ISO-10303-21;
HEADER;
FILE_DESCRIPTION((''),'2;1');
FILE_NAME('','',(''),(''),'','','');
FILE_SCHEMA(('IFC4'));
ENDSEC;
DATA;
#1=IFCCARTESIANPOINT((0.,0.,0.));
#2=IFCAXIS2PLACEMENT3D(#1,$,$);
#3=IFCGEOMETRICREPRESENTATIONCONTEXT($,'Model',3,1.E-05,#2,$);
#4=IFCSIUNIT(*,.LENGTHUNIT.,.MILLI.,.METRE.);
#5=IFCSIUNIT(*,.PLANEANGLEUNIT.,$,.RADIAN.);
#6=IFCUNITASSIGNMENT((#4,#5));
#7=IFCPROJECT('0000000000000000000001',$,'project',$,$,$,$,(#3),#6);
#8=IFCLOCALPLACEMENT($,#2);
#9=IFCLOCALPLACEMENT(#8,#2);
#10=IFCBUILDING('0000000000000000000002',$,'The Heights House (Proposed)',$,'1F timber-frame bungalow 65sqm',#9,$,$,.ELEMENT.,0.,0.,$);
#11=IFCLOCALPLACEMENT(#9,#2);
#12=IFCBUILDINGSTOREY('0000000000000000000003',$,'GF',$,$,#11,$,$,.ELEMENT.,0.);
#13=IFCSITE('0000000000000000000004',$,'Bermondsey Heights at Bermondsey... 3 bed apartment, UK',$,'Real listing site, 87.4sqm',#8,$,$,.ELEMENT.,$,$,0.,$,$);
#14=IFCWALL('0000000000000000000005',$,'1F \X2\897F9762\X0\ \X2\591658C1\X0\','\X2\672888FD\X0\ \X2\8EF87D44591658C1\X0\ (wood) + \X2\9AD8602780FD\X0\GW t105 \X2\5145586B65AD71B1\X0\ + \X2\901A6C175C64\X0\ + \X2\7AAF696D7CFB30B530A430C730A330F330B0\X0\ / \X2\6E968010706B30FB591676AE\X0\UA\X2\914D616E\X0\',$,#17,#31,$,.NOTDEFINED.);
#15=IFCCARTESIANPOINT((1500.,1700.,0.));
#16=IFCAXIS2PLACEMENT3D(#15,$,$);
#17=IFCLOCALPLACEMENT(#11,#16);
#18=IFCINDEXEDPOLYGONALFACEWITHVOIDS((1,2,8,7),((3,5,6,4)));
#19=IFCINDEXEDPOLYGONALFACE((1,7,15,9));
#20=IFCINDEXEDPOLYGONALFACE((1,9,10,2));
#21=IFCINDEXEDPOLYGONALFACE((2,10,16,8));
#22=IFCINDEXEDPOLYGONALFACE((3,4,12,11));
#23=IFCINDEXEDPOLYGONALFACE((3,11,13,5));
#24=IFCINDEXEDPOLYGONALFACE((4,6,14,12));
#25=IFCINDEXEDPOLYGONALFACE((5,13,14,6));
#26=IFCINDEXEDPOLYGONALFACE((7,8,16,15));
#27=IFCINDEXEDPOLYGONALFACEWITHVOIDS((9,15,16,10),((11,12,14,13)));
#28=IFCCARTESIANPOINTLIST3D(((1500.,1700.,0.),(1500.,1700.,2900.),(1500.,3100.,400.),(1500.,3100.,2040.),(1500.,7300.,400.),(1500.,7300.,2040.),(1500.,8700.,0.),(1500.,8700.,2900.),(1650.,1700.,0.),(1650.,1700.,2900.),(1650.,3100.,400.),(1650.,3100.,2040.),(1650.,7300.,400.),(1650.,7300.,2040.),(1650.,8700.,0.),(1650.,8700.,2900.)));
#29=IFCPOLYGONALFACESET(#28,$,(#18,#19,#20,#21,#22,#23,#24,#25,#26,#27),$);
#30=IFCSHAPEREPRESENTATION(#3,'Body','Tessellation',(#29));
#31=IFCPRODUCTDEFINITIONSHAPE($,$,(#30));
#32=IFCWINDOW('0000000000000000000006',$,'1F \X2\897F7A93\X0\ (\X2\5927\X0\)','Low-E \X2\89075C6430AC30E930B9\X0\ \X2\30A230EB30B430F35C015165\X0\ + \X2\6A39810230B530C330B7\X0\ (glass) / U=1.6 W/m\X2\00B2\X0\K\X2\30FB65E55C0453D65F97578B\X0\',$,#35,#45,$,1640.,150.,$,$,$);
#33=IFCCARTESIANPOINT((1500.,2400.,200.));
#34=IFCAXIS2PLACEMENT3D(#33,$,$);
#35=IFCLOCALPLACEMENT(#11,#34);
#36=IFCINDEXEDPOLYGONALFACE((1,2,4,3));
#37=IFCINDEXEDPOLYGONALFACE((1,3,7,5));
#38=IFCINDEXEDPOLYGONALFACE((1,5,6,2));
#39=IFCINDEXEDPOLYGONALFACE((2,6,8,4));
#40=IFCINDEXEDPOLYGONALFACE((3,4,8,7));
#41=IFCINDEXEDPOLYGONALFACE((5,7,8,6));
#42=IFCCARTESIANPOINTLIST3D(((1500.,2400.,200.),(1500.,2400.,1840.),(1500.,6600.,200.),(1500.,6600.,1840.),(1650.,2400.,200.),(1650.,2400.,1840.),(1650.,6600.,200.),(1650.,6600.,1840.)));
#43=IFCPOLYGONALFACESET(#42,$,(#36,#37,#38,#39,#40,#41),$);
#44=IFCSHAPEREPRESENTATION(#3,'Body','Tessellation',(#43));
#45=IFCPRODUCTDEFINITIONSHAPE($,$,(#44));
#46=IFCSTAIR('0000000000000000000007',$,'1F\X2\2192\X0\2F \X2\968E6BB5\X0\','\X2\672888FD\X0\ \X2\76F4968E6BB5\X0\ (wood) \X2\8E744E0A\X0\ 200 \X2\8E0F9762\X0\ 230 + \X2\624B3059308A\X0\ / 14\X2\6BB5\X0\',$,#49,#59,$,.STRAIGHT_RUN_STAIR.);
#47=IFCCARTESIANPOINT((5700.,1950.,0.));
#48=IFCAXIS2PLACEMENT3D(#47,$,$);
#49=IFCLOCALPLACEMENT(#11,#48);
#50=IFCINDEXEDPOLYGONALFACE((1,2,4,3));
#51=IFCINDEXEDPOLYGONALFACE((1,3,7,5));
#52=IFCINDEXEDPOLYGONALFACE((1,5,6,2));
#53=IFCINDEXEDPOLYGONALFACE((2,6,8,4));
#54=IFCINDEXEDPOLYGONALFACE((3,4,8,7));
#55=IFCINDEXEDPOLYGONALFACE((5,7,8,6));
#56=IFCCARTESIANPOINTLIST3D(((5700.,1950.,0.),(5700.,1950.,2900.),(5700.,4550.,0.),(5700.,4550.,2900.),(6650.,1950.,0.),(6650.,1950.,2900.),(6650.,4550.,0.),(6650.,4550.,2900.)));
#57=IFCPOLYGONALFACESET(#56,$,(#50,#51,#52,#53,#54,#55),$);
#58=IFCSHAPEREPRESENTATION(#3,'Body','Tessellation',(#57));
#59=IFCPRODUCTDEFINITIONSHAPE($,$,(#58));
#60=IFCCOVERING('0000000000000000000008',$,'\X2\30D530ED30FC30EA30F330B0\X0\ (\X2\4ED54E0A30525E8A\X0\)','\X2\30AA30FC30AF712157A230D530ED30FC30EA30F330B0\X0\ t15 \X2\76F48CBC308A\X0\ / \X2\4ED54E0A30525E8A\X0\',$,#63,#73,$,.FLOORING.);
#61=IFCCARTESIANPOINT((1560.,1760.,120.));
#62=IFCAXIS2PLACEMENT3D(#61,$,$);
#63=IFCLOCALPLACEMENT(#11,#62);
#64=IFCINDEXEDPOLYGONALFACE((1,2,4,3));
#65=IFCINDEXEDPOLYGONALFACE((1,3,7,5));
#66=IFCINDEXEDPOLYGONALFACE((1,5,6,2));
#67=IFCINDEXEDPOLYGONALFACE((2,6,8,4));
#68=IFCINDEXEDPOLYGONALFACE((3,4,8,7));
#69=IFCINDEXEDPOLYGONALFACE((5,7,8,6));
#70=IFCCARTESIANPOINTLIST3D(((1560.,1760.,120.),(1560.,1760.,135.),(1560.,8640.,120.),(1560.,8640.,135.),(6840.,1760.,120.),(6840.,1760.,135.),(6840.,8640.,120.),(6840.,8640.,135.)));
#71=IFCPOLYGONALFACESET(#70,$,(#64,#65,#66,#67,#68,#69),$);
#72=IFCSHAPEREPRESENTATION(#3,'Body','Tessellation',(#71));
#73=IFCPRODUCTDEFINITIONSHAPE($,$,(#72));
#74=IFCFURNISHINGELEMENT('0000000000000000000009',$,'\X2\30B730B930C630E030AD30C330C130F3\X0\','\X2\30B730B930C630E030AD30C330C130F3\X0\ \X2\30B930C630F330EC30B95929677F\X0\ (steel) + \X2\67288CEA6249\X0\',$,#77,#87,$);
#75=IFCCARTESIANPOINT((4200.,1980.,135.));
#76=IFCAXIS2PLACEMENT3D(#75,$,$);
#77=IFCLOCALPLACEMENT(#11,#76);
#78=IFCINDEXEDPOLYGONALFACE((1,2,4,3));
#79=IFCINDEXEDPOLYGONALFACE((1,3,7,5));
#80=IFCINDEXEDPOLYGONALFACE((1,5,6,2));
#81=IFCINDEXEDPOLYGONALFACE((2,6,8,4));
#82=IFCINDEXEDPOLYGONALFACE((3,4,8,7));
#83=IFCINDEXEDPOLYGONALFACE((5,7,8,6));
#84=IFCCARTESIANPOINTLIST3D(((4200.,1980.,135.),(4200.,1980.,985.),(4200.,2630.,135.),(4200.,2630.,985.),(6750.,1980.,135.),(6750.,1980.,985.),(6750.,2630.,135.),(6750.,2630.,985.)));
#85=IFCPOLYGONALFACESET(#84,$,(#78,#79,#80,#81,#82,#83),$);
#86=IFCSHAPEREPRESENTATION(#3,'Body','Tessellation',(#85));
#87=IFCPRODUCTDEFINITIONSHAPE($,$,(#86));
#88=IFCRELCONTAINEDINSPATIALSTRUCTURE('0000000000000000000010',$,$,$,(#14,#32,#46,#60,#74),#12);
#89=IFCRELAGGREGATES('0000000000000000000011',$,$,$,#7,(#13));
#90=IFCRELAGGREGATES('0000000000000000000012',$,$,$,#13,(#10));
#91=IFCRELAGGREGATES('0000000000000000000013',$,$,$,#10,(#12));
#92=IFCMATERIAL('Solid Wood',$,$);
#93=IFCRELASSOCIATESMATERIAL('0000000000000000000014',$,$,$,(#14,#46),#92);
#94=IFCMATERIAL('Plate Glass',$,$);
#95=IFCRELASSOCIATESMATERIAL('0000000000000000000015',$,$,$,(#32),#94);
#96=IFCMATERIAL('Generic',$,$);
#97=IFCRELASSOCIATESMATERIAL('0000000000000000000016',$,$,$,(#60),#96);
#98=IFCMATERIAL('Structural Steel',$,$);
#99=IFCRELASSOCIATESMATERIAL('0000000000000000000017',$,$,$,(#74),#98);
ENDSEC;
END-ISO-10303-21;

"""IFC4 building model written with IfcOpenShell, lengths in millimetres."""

from ifc_helpers import new_model, si_unit, frame, frame_2d, origin, place, context, project, spatial, rectangle, extrude, material, element, fill, save


model = new_model("IFC4")

# Units and contexts
model_context = context("Model", 3, precision=1e-05, world=origin())
ifc_project = project(units=[si_unit("LENGTHUNIT", "METRE", prefix="MILLI"), si_unit("PLANEANGLEUNIT", "RADIAN")], contexts=[model_context])

# Site, building, storey
site_placement = place(None, origin())
site = spatial("IfcSite", under=ifc_project, at=site_placement, Name="Bermondsey Heights at Bermondsey... 3 bed apartment, UK", ObjectType="Real listing site, 87.4sqm", CompositionType="ELEMENT", RefElevation=0.0)
building_placement = place(site_placement, origin())
building = spatial("IfcBuilding", under=site, at=building_placement, Name="The Heights House (Proposed)", ObjectType="1F timber-frame bungalow 65sqm", CompositionType="ELEMENT", ElevationOfRefHeight=0.0, ElevationOfTerrain=0.0)
storey_placement = place(building_placement, origin())
storey = spatial("IfcBuildingStorey", under=building, at=storey_placement, Name="GF", CompositionType="ELEMENT", Elevation=0.0)

# Shared definitions
ifc_material_1 = material(Name="Solid Wood")
ifc_material_2 = material(Name="Generic")

# Shared definitions
ifc_material_3 = material(Name="Plate Glass")

# Wall, opening, window
wall_1_placement = place(storey_placement, frame((1500.0, 1700.0, 0.0)))
wall_1 = element("IfcWall", 1, at=wall_1_placement, inside=storey, material=ifc_material_1, Name="1F 西面 外壁", Description="木製 軸組外壁 (wood) + 高性能GW t105 充填断熱 + 通気層 + 窯業系サイディング / 準耐火・外皮UA配慮", PredefinedType="NOTDEFINED", context=model_context, shape_type="SweptSolid", body=[
    extrude(rectangle(XDim=150.0, YDim=7000.0, at=frame_2d((75.0, 3500.0))), frame((1500.0, 1700.0, 0.0)), (0.0, 0.0, 1.0), 2900.0),
])
opening_1_placement = place(storey_placement, frame((1500.0, 2400.0, 200.0)))
opening_1 = element("IfcOpeningElement", 2, at=opening_1_placement, cuts=wall_1, PredefinedType="NOTDEFINED", context=model_context, shape_type="SweptSolid", body=[
    extrude(rectangle(XDim=150.0, YDim=4200.0, at=frame_2d((75.0, 2100.0))), frame((1500.0, 2400.0, 200.0)), (0.0, 0.0, 1.0), 1640.0),
])
window_1_placement = place(storey_placement, frame((1500.0, 2400.0, 200.0)))
window_1 = element("IfcWindow", 3, at=window_1_placement, inside=storey, material=ifc_material_3, Name="1F 西窓 (大)", Description="Low-E 複層ガラス アルゴン封入 + 樹脂サッシ (glass) / U=1.6 W/m²K・日射取得型", OverallHeight=1640.0, OverallWidth=150.0, context=model_context, shape_type="SweptSolid", body=[
    extrude(rectangle(XDim=150.0, YDim=4200.0, at=frame_2d((75.0, 2100.0))), frame((1500.0, 2400.0, 200.0)), (0.0, 0.0, 1.0), 1640.0),
])
fill(opening_1, window_1)

# Stair
stair_placement = place(storey_placement, frame((5700.0, 1950.0, 0.0)))
element("IfcStair", 4, at=stair_placement, inside=storey, material=ifc_material_1, Name="1F→2F 階段", Description="木製 直階段 (wood) 蹴上 200 踏面 230 + 手すり / 14段", PredefinedType="STRAIGHT_RUN_STAIR", context=model_context, shape_type="SweptSolid", body=[
    extrude(rectangle(XDim=950.0, YDim=2600.0, at=frame_2d((475.0, 1300.0))), frame((5700.0, 1950.0, 0.0)), (0.0, 0.0, 1.0), 2900.0),
])

# Covering
covering_placement = place(storey_placement, frame((1560.0, 1760.0, 120.0)))
element("IfcCovering", 5, at=covering_placement, inside=storey, material=ifc_material_2, Name="フローリング (仕上げ床)", Description="オーク無垢フローリング t15 直貼り / 仕上げ床", PredefinedType="FLOORING", context=model_context, shape_type="SweptSolid", body=[
    extrude(rectangle(XDim=5280.0, YDim=6880.0, at=frame_2d((2640.0, 3440.0))), frame((1560.0, 1760.0, 120.0)), (0.0, 0.0, 1.0), 15.0),
])

# Furnishing element
ifc_material_4 = material(Name="Structural Steel")
furnishing_placement = place(storey_placement, frame((4200.0, 1980.0, 135.0)))
element("IfcFurnishingElement", 6, at=furnishing_placement, inside=storey, material=ifc_material_4, Name="システムキッチン", Description="システムキッチン ステンレス天板 (steel) + 木質扉", context=model_context, shape_type="SweptSolid", body=[
    extrude(rectangle(XDim=2550.0, YDim=650.0, at=frame_2d((1275.0, 325.0))), frame((4200.0, 1980.0, 135.0)), (0.0, 0.0, 1.0), 850.0),
])

save(model, "model.ifc")
